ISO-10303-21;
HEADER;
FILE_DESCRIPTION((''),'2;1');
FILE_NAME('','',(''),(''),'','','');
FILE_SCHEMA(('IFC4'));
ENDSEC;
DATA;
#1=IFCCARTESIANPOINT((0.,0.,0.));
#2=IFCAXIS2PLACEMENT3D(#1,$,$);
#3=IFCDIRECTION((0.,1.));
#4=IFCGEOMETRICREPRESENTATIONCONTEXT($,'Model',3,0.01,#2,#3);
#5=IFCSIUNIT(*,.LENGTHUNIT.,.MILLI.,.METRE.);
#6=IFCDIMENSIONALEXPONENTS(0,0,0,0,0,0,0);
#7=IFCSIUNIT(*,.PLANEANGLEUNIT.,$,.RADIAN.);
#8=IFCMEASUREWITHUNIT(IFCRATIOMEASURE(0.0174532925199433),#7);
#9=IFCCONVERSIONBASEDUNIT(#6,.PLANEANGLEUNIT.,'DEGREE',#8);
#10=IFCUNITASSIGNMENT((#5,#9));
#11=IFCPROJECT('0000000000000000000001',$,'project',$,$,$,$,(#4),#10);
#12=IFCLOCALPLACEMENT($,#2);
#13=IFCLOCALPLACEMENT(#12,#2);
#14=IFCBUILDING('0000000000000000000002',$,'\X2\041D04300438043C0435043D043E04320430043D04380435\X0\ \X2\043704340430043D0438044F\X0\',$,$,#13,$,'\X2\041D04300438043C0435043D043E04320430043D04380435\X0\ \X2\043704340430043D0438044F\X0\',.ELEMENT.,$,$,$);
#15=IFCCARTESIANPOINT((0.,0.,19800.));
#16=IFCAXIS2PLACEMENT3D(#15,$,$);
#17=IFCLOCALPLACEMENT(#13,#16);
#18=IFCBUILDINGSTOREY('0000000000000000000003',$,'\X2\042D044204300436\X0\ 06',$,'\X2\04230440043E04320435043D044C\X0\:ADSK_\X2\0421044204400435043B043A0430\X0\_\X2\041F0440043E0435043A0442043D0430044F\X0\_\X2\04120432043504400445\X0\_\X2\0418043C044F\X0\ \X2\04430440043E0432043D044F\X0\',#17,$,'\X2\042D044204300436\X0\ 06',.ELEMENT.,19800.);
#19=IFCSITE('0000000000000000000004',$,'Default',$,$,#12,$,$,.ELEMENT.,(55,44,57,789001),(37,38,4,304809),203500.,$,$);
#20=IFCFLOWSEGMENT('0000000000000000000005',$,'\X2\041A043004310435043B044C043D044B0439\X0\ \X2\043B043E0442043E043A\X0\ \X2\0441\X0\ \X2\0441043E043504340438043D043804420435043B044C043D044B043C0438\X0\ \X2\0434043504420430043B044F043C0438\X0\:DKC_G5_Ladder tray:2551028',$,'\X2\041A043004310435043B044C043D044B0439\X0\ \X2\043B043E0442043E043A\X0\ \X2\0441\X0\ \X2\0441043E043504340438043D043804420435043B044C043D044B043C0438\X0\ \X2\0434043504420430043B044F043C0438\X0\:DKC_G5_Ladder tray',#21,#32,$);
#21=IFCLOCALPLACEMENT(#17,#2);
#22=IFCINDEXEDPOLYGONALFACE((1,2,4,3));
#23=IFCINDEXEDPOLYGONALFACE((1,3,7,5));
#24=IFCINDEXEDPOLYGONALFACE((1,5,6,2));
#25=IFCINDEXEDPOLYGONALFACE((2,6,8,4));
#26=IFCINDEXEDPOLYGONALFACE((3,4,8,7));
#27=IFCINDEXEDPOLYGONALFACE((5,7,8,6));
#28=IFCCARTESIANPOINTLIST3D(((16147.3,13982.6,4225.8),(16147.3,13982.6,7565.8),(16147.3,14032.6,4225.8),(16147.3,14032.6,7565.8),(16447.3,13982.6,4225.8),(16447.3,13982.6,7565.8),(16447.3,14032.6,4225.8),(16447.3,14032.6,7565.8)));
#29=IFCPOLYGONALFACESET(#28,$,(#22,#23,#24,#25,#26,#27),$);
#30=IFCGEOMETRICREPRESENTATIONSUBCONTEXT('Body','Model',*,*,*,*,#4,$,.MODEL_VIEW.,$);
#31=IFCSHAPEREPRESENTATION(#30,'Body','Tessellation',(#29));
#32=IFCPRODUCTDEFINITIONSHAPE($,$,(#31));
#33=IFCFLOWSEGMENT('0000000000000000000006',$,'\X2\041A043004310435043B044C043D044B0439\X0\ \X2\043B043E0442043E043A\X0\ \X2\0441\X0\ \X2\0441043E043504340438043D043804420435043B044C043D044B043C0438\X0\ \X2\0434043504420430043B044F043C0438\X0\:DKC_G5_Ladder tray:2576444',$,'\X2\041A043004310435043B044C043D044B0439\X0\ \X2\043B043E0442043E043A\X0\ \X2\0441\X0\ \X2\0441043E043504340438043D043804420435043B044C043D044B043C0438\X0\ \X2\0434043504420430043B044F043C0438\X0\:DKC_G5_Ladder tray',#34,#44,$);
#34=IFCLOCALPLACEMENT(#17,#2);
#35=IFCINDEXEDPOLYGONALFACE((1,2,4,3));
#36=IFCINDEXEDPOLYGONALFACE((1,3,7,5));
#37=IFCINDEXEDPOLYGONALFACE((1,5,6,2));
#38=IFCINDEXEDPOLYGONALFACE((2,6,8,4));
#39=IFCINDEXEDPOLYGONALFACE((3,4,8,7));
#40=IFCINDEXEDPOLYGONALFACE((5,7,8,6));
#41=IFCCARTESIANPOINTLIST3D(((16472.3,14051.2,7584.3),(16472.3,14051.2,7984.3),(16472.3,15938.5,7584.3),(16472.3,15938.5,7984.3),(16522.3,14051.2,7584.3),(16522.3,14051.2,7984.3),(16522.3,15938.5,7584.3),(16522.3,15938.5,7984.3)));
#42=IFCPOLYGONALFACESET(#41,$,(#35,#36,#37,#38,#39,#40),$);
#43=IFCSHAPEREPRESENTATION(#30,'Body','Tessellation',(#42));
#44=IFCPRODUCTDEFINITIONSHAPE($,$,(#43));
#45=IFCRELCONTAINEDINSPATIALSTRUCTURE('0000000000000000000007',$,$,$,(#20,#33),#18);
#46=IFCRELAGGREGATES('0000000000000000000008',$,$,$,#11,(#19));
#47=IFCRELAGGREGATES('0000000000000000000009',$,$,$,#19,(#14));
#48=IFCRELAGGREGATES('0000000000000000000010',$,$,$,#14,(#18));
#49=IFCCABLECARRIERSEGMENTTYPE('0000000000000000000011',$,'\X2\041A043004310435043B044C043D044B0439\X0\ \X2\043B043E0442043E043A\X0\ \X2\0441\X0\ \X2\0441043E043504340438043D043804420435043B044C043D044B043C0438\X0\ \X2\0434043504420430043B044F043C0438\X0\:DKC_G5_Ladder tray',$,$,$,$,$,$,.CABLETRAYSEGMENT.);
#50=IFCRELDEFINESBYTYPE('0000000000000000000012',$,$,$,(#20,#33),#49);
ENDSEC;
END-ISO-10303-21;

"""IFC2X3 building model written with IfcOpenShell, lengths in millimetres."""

from ifc_helpers import new_model, entity, si_unit, converted_unit, direction, frame, origin, origin_2d_with_axis, place, context, subcontext, project, spatial, rectangle, extrude, type_object, element, save


model = new_model("IFC2X3")

# Units and contexts
model_context = context("Model", 3, precision=0.01, world=origin(), true_north=direction((0.0, 1.0)))
body_context = subcontext(model_context, "Body", "Model", "MODEL_VIEW")
ifc_project = project(units=[si_unit("LENGTHUNIT", "METRE", prefix="MILLI"), converted_unit("PLANEANGLEUNIT", "DEGREE", entity("IfcRatioMeasure", 0.0174532925199433), si_unit("PLANEANGLEUNIT", "RADIAN"), dimensions=[0, 0, 0, 0, 0, 0, 0])], contexts=[model_context])

# Site, building, storey
site_placement = place(None, frame((0.0, 0.0, 0.0)))
site = spatial("IfcSite", under=ifc_project, at=site_placement, Name="Default", CompositionType="ELEMENT", RefLatitude=(55, 44, 57, 789001), RefLongitude=(37, 38, 4, 304809), RefElevation=203500.0)
building_placement = place(site_placement, origin())
building = spatial("IfcBuilding", under=site, at=building_placement, Name="Наименование здания", LongName="Наименование здания", CompositionType="ELEMENT")
storey_placement = place(building_placement, frame((0.0, 0.0, 19800.0)))
storey = spatial("IfcBuildingStorey", under=building, at=storey_placement, Name="Этаж 06", ObjectType="Уровень:ADSK_Стрелка_Проектная_Вверх_Имя уровня", LongName="Этаж 06", CompositionType="ELEMENT", Elevation=19800.0)

# Flow segments
cable_carrier_segment_type_1 = type_object("IfcCableCarrierSegmentType", Name="Кабельный лоток с соединительными деталями:DKC_G5_Ladder tray", PredefinedType="CABLETRAYSEGMENT")
flow_segment_1_placement = place(storey_placement, frame((16147.3, 13982.6, 4225.8)))
element("IfcFlowSegment", 1, at=flow_segment_1_placement, inside=storey, type_object=cable_carrier_segment_type_1, Name="Кабельный лоток с соединительными деталями:DKC_G5_Ladder tray:2551028", ObjectType="Кабельный лоток с соединительными деталями:DKC_G5_Ladder tray", context=body_context, shape_type="SweptSolid", body=[
    extrude(rectangle(XDim=50.0, YDim=300.0, at=origin_2d_with_axis()), frame((150.0, 25.0, 0.0), z_axis=(0.0, 0.0, 1.0), x_axis=(0.0, 1.0, 0.0)), (0.0, 0.0, 1.0), 3340.0),
])
flow_segment_2_placement = place(storey_placement, frame((16472.3, 14051.2, 7584.3)))
element("IfcFlowSegment", 2, at=flow_segment_2_placement, inside=storey, type_object=cable_carrier_segment_type_1, Name="Кабельный лоток с соединительными деталями:DKC_G5_Ladder tray:2576444", ObjectType="Кабельный лоток с соединительными деталями:DKC_G5_Ladder tray", context=body_context, shape_type="SweptSolid", body=[
    extrude(rectangle(XDim=1887.3, YDim=50.0, at=origin_2d_with_axis()), frame((25.0, 943.7, 0.0), z_axis=(0.0, 0.0, 1.0), x_axis=(0.0, -1.0, 0.0)), (0.0, 0.0, 1.0), 400.0),
])

save(model, "model.ifc")
